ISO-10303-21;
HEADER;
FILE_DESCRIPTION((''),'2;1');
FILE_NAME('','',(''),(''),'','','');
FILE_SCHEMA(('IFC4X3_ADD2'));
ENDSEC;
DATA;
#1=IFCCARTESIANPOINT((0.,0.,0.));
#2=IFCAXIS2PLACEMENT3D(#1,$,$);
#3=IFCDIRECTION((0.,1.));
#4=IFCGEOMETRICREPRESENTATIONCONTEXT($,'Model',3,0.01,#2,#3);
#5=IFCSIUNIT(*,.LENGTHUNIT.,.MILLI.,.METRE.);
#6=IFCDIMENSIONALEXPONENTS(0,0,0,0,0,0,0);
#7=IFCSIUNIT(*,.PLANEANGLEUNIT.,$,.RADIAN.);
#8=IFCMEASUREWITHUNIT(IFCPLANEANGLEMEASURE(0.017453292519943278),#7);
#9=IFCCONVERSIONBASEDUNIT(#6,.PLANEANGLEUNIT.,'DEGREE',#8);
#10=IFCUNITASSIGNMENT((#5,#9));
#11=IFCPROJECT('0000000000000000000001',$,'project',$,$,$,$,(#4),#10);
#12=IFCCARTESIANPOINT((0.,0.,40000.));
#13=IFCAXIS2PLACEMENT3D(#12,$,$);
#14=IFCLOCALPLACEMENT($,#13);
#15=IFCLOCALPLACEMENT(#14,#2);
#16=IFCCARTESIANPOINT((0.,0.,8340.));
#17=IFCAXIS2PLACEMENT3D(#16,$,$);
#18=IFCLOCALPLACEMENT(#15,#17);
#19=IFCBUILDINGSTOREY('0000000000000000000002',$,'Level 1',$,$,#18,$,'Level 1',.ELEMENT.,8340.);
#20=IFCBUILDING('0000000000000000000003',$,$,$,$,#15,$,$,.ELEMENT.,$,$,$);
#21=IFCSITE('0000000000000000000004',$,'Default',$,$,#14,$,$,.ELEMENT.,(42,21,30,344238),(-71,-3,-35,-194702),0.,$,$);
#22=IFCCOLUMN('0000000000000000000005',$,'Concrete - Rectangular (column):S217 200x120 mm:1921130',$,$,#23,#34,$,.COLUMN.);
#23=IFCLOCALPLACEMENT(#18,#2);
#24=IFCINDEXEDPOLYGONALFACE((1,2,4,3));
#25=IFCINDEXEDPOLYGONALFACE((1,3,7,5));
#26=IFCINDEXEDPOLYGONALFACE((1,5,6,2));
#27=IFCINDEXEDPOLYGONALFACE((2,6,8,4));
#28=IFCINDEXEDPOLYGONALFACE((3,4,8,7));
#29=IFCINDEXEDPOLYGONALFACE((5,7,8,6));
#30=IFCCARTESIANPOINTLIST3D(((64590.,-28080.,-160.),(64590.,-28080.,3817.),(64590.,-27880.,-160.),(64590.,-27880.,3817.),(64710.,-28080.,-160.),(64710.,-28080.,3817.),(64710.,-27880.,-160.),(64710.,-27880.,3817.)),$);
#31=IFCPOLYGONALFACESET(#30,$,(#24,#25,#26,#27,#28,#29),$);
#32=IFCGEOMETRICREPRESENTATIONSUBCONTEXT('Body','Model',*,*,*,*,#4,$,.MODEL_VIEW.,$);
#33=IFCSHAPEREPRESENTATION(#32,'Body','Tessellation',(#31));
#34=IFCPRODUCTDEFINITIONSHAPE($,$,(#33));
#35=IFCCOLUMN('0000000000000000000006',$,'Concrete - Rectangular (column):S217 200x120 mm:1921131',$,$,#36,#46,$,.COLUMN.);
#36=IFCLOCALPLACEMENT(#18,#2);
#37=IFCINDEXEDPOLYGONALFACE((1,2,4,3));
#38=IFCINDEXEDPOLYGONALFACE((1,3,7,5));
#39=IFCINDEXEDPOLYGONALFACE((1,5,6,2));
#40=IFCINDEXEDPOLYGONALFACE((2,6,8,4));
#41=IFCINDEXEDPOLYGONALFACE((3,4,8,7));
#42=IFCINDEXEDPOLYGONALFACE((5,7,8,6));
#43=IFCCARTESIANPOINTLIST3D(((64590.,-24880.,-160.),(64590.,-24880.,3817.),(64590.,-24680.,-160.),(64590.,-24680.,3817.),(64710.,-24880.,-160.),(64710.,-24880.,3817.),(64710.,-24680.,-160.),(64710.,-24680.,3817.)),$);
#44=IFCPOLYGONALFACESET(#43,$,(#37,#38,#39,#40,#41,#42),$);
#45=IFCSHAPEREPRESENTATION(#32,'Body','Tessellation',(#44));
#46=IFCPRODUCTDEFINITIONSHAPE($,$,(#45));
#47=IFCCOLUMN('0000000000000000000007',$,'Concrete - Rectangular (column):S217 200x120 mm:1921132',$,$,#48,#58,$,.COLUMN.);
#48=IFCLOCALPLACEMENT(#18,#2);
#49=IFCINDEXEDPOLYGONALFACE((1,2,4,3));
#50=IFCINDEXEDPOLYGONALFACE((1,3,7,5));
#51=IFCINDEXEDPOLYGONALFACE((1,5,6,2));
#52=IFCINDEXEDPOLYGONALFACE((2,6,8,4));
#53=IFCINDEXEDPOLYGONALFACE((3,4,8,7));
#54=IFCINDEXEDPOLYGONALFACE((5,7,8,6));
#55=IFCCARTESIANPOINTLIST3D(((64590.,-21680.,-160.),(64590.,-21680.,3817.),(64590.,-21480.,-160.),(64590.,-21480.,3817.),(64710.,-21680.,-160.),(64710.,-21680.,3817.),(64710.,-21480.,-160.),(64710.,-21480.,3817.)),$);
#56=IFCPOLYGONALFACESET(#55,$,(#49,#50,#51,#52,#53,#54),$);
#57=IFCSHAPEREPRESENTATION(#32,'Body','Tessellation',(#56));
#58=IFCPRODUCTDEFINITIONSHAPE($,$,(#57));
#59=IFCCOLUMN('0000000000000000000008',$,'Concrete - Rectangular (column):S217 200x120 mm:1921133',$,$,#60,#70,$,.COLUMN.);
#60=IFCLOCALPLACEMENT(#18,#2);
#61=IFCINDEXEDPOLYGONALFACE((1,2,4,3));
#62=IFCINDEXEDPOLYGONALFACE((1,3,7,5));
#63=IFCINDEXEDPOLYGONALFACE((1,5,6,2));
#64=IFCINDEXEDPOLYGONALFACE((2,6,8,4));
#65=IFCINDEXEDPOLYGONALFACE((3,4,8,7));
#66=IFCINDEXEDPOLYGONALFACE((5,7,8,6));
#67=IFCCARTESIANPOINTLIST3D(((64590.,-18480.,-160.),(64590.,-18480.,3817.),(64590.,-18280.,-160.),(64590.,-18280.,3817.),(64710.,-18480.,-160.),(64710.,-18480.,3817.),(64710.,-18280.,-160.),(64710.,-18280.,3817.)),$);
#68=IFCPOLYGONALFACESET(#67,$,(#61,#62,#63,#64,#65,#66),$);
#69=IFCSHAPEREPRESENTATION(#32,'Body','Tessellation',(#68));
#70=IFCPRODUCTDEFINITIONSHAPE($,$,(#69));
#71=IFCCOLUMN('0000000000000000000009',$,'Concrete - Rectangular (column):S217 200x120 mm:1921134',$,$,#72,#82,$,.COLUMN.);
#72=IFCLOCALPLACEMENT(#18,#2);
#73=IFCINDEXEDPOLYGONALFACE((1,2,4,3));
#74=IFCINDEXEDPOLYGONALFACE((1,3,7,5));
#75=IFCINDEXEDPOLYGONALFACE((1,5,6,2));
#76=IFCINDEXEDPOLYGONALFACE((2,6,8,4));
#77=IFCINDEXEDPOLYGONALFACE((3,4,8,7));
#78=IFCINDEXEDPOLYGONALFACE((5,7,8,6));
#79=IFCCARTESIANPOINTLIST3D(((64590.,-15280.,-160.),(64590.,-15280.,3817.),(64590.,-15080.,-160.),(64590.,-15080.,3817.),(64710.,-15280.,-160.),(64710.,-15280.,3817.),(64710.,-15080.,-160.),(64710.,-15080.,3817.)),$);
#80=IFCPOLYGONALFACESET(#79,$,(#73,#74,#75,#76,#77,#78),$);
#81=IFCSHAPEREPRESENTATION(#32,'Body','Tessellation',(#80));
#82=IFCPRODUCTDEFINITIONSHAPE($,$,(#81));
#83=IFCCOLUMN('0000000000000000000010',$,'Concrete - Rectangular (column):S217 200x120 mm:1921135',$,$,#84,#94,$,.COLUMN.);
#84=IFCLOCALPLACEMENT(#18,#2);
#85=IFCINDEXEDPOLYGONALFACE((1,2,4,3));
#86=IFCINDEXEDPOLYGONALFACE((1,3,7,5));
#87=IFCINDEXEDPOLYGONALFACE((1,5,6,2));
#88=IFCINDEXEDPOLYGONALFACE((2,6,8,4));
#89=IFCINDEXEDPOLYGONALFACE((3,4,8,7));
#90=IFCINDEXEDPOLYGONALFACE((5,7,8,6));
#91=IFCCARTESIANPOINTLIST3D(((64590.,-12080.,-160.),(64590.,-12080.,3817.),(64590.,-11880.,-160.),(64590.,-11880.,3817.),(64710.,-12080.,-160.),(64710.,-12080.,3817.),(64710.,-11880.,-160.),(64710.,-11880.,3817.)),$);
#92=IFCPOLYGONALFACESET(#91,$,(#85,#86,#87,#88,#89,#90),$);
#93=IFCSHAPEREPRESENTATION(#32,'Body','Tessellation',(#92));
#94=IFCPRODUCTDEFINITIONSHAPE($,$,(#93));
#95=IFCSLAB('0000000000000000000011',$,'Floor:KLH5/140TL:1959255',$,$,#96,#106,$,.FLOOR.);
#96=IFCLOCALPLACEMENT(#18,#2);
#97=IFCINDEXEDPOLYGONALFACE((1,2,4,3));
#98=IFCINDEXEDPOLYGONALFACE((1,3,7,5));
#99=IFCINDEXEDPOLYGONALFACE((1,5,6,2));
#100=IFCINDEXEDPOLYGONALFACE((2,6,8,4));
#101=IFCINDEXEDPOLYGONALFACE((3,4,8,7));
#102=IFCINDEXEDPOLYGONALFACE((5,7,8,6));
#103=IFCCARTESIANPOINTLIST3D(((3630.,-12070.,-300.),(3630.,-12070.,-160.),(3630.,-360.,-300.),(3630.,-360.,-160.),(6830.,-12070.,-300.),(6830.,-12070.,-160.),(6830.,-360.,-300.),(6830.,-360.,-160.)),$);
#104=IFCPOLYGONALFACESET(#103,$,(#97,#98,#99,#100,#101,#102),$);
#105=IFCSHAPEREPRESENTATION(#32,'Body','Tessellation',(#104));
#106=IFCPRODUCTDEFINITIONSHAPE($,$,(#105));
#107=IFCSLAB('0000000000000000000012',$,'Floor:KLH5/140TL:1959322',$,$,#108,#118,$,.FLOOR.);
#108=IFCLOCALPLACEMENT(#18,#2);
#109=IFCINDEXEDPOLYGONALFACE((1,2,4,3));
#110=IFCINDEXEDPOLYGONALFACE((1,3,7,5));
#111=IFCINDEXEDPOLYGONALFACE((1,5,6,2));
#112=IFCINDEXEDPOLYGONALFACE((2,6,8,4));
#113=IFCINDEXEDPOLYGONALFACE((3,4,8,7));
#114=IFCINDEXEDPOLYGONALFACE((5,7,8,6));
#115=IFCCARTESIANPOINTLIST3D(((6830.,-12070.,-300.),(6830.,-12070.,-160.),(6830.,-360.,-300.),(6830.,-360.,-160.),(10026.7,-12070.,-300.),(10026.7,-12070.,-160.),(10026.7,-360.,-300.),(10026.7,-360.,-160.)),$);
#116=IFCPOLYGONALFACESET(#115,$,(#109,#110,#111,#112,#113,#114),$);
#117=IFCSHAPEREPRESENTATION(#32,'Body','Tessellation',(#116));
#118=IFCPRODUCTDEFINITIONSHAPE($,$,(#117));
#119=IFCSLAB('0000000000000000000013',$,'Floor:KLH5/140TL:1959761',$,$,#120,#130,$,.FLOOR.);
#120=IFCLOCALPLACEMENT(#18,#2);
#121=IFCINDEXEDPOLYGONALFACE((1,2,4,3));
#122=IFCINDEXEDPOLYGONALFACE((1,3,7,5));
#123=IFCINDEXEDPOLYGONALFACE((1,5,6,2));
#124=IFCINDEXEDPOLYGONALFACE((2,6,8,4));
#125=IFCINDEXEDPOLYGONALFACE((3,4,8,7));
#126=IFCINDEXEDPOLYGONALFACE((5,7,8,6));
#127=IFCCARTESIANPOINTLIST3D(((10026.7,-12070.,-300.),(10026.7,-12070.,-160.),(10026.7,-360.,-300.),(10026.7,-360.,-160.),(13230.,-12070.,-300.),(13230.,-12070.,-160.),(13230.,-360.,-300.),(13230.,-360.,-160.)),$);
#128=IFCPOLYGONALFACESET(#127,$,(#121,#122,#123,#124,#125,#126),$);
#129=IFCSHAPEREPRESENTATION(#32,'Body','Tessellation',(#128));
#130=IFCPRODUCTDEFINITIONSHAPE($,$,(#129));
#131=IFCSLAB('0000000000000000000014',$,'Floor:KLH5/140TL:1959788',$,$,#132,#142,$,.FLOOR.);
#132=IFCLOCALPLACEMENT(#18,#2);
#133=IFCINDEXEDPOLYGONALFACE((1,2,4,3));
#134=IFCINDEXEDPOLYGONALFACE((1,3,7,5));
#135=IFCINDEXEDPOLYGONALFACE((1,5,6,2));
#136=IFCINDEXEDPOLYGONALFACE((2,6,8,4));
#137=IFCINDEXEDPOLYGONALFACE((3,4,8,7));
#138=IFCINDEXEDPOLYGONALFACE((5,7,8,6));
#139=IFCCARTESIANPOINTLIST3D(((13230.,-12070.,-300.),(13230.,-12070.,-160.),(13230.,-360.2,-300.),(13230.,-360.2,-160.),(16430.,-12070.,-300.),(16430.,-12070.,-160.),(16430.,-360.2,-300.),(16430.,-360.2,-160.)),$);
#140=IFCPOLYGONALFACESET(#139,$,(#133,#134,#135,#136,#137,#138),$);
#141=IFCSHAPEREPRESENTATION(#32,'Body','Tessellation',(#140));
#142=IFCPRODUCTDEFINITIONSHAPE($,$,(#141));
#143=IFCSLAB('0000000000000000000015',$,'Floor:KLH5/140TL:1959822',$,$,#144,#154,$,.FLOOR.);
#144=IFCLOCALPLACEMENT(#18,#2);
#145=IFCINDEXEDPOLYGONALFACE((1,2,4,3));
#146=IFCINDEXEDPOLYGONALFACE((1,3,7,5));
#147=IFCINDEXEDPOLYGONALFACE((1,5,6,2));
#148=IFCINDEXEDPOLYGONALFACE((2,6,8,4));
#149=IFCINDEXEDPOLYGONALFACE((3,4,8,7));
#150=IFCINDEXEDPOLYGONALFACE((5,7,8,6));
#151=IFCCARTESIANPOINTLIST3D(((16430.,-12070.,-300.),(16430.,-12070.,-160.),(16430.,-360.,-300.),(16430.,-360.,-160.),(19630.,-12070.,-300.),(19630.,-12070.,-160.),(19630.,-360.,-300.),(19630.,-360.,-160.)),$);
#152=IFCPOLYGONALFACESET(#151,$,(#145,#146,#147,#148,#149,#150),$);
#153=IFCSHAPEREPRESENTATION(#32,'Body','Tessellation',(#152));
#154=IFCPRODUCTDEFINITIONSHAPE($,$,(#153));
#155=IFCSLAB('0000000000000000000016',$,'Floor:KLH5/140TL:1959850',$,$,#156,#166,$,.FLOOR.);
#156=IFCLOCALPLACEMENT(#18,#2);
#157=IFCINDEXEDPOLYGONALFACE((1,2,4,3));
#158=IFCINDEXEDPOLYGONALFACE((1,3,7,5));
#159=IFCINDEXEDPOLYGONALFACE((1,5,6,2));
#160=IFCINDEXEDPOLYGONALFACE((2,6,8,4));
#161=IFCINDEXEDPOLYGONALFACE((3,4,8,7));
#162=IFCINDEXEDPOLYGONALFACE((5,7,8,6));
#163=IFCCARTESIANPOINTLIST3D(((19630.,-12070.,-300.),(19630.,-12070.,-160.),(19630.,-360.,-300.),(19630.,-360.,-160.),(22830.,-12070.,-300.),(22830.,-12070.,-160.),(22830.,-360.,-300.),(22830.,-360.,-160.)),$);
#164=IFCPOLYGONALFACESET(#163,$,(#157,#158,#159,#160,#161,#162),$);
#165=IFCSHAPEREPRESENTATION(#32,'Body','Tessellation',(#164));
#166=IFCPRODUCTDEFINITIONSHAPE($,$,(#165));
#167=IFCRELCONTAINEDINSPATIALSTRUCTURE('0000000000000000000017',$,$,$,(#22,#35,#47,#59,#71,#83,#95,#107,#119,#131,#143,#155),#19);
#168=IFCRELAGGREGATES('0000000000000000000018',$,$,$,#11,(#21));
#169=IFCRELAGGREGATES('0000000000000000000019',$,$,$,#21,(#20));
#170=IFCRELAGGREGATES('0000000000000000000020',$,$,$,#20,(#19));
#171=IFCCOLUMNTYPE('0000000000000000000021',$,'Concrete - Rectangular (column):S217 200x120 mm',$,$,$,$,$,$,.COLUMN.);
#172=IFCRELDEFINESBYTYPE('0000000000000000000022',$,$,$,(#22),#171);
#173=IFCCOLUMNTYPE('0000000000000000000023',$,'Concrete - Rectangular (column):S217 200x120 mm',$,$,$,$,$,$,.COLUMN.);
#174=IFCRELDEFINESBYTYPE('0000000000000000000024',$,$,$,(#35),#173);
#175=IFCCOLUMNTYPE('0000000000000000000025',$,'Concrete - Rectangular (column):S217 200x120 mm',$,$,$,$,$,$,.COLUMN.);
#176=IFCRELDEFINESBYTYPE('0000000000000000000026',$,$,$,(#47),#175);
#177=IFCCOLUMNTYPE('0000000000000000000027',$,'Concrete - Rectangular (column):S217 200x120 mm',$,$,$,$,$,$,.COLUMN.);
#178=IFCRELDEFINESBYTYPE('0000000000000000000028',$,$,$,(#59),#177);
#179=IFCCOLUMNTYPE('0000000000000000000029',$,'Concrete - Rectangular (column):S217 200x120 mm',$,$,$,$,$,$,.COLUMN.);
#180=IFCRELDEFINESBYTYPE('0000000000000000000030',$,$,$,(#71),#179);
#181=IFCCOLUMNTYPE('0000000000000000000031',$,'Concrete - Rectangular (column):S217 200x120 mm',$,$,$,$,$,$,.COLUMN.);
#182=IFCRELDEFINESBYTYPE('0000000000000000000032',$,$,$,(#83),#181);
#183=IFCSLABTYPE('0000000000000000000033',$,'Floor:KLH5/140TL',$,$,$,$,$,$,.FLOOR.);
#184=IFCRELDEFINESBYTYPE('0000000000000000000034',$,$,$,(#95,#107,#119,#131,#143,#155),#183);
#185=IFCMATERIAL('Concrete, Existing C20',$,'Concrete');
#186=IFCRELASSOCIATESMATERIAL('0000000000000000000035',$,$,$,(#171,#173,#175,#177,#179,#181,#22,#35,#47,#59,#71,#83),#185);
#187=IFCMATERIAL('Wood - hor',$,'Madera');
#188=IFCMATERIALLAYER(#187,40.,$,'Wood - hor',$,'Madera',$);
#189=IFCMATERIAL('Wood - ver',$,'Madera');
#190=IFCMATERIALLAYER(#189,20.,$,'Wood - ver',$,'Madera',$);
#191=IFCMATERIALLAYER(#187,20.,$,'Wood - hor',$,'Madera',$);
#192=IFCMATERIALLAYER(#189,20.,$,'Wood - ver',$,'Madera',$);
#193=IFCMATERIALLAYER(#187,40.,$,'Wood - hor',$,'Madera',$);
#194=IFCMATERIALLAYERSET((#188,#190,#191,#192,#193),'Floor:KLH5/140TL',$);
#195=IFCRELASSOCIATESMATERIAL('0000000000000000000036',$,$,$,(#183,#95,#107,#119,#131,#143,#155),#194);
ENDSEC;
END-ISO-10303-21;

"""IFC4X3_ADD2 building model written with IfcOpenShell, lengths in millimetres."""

from ifc_helpers import new_model, entity, si_unit, converted_unit, direction, frame, frame_2d, origin, origin_2d_with_axis, place, context, subcontext, project, spatial, rectangle, extrude, source, transform, mapped, material, layer, layer_set, layer_usage, material_profile, profile_set, profile_usage, type_object, type_shapes, element, save


model = new_model("IFC4X3_ADD2")

# Units and contexts
model_context = context("Model", 3, precision=0.01, world=origin(), true_north=direction((0.0, 1.0)))
body_context = subcontext(model_context, "Body", "Model", "MODEL_VIEW")
ifc_project = project(units=[si_unit("LENGTHUNIT", "METRE", prefix="MILLI"), converted_unit("PLANEANGLEUNIT", "DEGREE", entity("IfcPlaneAngleMeasure", 0.017453292519943278), si_unit("PLANEANGLEUNIT", "RADIAN"), dimensions=[0, 0, 0, 0, 0, 0, 0])], contexts=[model_context])

# Site, building, storey
site_placement = place(None, frame((0.0, 0.0, 40000.0)))
site = spatial("IfcSite", under=ifc_project, at=site_placement, Name="Default", CompositionType="ELEMENT", RefLatitude=(42, 21, 30, 344238), RefLongitude=(-71, -3, -35, -194702), RefElevation=0.0)
building_placement = place(site_placement, origin())
building = spatial("IfcBuilding", under=site, at=building_placement, CompositionType="ELEMENT")
storey_placement = place(building_placement, frame((0.0, 0.0, 8340.0)))
storey = spatial("IfcBuildingStorey", under=building, at=storey_placement, Name="Level 1", LongName="Level 1", CompositionType="ELEMENT", Elevation=8340.0)

# Columns
ifc_material_1 = material(Name="Concrete, Existing C20", Category="Concrete")
ifc_material_profile_1 = material_profile(ifc_material_1, rectangle(XDim=200.0, YDim=120.0, at=frame_2d((0.0, 0.0), x_axis=(1.0, 0.0))), Name="S217 200x120 mm")
ifc_profile_set_1 = profile_set([ifc_material_profile_1], Name="S217 200x120 mm")
ifc_profile_usage_1 = profile_usage(ifc_profile_set_1)
column_type_1 = type_object("IfcColumnType", Name="Concrete - Rectangular (column):S217 200x120 mm", PredefinedType="COLUMN", material=ifc_profile_set_1)
shared_shape_1 = source(origin(), body_context, "Body", "SweptSolid", [
    extrude(rectangle(XDim=200.0, YDim=120.0, at=frame_2d((0.0, 0.0), x_axis=(1.0, 0.0))), frame((64650.0, -27980.0, 8180.0), z_axis=(0.0, 0.0, 1.0), x_axis=(0.0, 1.0, 0.0)), (0.0, 0.0, 1.0), 3977.0),
])
type_shapes(column_type_1, [shared_shape_1])
column_1_placement = place(storey_placement, frame((0.0, 0.0, -8340.0)))
element("IfcColumn", 1, at=column_1_placement, inside=storey, type_object=column_type_1, material=ifc_profile_usage_1, Name="Concrete - Rectangular (column):S217 200x120 mm:1921130", PredefinedType="COLUMN", context=body_context, shape_type="MappedRepresentation", body=[
    mapped(shared_shape_1, transform((0.0, 0.0, 0.0), scale=1.0)),
])
column_type_2 = type_object("IfcColumnType", Name="Concrete - Rectangular (column):S217 200x120 mm", PredefinedType="COLUMN", material=ifc_profile_set_1)
shared_shape_2 = source(origin(), body_context, "Body", "SweptSolid", [
    extrude(rectangle(XDim=200.0, YDim=120.0, at=frame_2d((0.0, 0.0), x_axis=(1.0, 0.0))), frame((64650.0, -24780.0, 8180.0), z_axis=(0.0, 0.0, 1.0), x_axis=(0.0, 1.0, 0.0)), (0.0, 0.0, 1.0), 3977.0),
])
type_shapes(column_type_2, [shared_shape_2])
column_2_placement = place(storey_placement, frame((0.0, 0.0, -8340.0)))
element("IfcColumn", 2, at=column_2_placement, inside=storey, type_object=column_type_2, material=ifc_profile_usage_1, Name="Concrete - Rectangular (column):S217 200x120 mm:1921131", PredefinedType="COLUMN", context=body_context, shape_type="MappedRepresentation", body=[
    mapped(shared_shape_2, transform((0.0, 0.0, 0.0), scale=1.0)),
])
column_type_3 = type_object("IfcColumnType", Name="Concrete - Rectangular (column):S217 200x120 mm", PredefinedType="COLUMN", material=ifc_profile_set_1)
shared_shape_3 = source(origin(), body_context, "Body", "SweptSolid", [
    extrude(rectangle(XDim=200.0, YDim=120.0, at=frame_2d((0.0, 0.0), x_axis=(1.0, 0.0))), frame((64650.0, -21580.0, 8180.0), z_axis=(0.0, 0.0, 1.0), x_axis=(0.0, 1.0, 0.0)), (0.0, 0.0, 1.0), 3977.0),
])
type_shapes(column_type_3, [shared_shape_3])
column_3_placement = place(storey_placement, frame((0.0, 0.0, -8340.0)))
element("IfcColumn", 3, at=column_3_placement, inside=storey, type_object=column_type_3, material=ifc_profile_usage_1, Name="Concrete - Rectangular (column):S217 200x120 mm:1921132", PredefinedType="COLUMN", context=body_context, shape_type="MappedRepresentation", body=[
    mapped(shared_shape_3, transform((0.0, 0.0, 0.0), scale=1.0)),
])
column_type_4 = type_object("IfcColumnType", Name="Concrete - Rectangular (column):S217 200x120 mm", PredefinedType="COLUMN", material=ifc_profile_set_1)
shared_shape_4 = source(origin(), body_context, "Body", "SweptSolid", [
    extrude(rectangle(XDim=200.0, YDim=120.0, at=frame_2d((0.0, 0.0), x_axis=(1.0, 0.0))), frame((64650.0, -18380.0, 8180.0), z_axis=(0.0, 0.0, 1.0), x_axis=(0.0, 1.0, 0.0)), (0.0, 0.0, 1.0), 3977.0),
])
type_shapes(column_type_4, [shared_shape_4])
column_4_placement = place(storey_placement, frame((0.0, 0.0, -8340.0)))
element("IfcColumn", 4, at=column_4_placement, inside=storey, type_object=column_type_4, material=ifc_profile_usage_1, Name="Concrete - Rectangular (column):S217 200x120 mm:1921133", PredefinedType="COLUMN", context=body_context, shape_type="MappedRepresentation", body=[
    mapped(shared_shape_4, transform((0.0, 0.0, 0.0), scale=1.0)),
])
column_type_5 = type_object("IfcColumnType", Name="Concrete - Rectangular (column):S217 200x120 mm", PredefinedType="COLUMN", material=ifc_profile_set_1)
shared_shape_5 = source(origin(), body_context, "Body", "SweptSolid", [
    extrude(rectangle(XDim=200.0, YDim=120.0, at=frame_2d((0.0, 0.0), x_axis=(1.0, 0.0))), frame((64650.0, -15180.0, 8180.0), z_axis=(0.0, 0.0, 1.0), x_axis=(0.0, 1.0, 0.0)), (0.0, 0.0, 1.0), 3977.0),
])
type_shapes(column_type_5, [shared_shape_5])
column_5_placement = place(storey_placement, frame((0.0, 0.0, -8340.0)))
element("IfcColumn", 5, at=column_5_placement, inside=storey, type_object=column_type_5, material=ifc_profile_usage_1, Name="Concrete - Rectangular (column):S217 200x120 mm:1921134", PredefinedType="COLUMN", context=body_context, shape_type="MappedRepresentation", body=[
    mapped(shared_shape_5, transform((0.0, 0.0, 0.0), scale=1.0)),
])
column_type_6 = type_object("IfcColumnType", Name="Concrete - Rectangular (column):S217 200x120 mm", PredefinedType="COLUMN", material=ifc_profile_set_1)
shared_shape_6 = source(origin(), body_context, "Body", "SweptSolid", [
    extrude(rectangle(XDim=200.0, YDim=120.0, at=frame_2d((0.0, 0.0), x_axis=(1.0, 0.0))), frame((64650.0, -11980.0, 8180.0), z_axis=(0.0, 0.0, 1.0), x_axis=(0.0, 1.0, 0.0)), (0.0, 0.0, 1.0), 3977.0),
])
type_shapes(column_type_6, [shared_shape_6])
column_6_placement = place(storey_placement, frame((0.0, 0.0, -8340.0)))
element("IfcColumn", 6, at=column_6_placement, inside=storey, type_object=column_type_6, material=ifc_profile_usage_1, Name="Concrete - Rectangular (column):S217 200x120 mm:1921135", PredefinedType="COLUMN", context=body_context, shape_type="MappedRepresentation", body=[
    mapped(shared_shape_6, transform((0.0, 0.0, 0.0), scale=1.0)),
])

# Slabs
ifc_material_2 = material(Name="Wood - hor", Category="Madera")
ifc_layer_1 = layer(ifc_material_2, 40.0, Name="Wood - hor", Category="Madera")
ifc_material_3 = material(Name="Wood - ver", Category="Madera")
ifc_layer_2 = layer(ifc_material_3, 20.0, Name="Wood - ver", Category="Madera")
ifc_layer_3 = layer(ifc_material_2, 20.0, Name="Wood - hor", Category="Madera")
ifc_layer_4 = layer(ifc_material_3, 20.0, Name="Wood - ver", Category="Madera")
ifc_layer_5 = layer(ifc_material_2, 40.0, Name="Wood - hor", Category="Madera")
ifc_layer_set = layer_set([ifc_layer_1, ifc_layer_2, ifc_layer_3, ifc_layer_4, ifc_layer_5], Name="Floor:KLH5/140TL")
ifc_layer_usage_1 = layer_usage(ifc_layer_set, "AXIS3", "POSITIVE", 0.0)
slab_type = type_object("IfcSlabType", Name="Floor:KLH5/140TL", PredefinedType="FLOOR", material=ifc_layer_set)
slab_1_placement = place(storey_placement, origin())
element("IfcSlab", 7, at=slab_1_placement, inside=storey, type_object=slab_type, material=ifc_layer_usage_1, Name="Floor:KLH5/140TL:1959255", PredefinedType="FLOOR", context=body_context, shape_type="SweptSolid", body=[
    extrude(rectangle(XDim=11710.0, YDim=3200.0, at=frame_2d((0.0, 0.0), x_axis=(1.0, 0.0))), frame((5230.0, -6215.0, -160.0), z_axis=(0.0, 0.0, -1.0), x_axis=(0.0, 1.0, 0.0)), (0.0, 0.0, 1.0), 140.0),
])
ifc_layer_usage_2 = layer_usage(ifc_layer_set, "AXIS3", "POSITIVE", 0.0)
slab_2_placement = place(storey_placement, origin())
element("IfcSlab", 8, at=slab_2_placement, inside=storey, type_object=slab_type, material=ifc_layer_usage_2, Name="Floor:KLH5/140TL:1959322", PredefinedType="FLOOR", context=body_context, shape_type="SweptSolid", body=[
    extrude(rectangle(XDim=11710.0, YDim=3196.7, at=frame_2d((0.0, 0.0), x_axis=(1.0, 0.0))), frame((8428.4, -6215.0, -160.0), z_axis=(0.0, 0.0, -1.0), x_axis=(0.0, 1.0, 0.0)), (0.0, 0.0, 1.0), 140.0),
])
ifc_layer_usage_3 = layer_usage(ifc_layer_set, "AXIS3", "POSITIVE", 0.0)
slab_3_placement = place(storey_placement, origin())
element("IfcSlab", 9, at=slab_3_placement, inside=storey, type_object=slab_type, material=ifc_layer_usage_3, Name="Floor:KLH5/140TL:1959761", PredefinedType="FLOOR", context=body_context, shape_type="SweptSolid", body=[
    extrude(rectangle(XDim=11710.0, YDim=3203.3, at=origin_2d_with_axis()), frame((11628.4, -6215.0, -160.0), z_axis=(0.0, 0.0, -1.0), x_axis=(0.0, 1.0, 0.0)), (0.0, 0.0, 1.0), 140.0),
])
ifc_layer_usage_4 = layer_usage(ifc_layer_set, "AXIS3", "POSITIVE", 0.0)
slab_4_placement = place(storey_placement, origin())
element("IfcSlab", 10, at=slab_4_placement, inside=storey, type_object=slab_type, material=ifc_layer_usage_4, Name="Floor:KLH5/140TL:1959788", PredefinedType="FLOOR", context=body_context, shape_type="SweptSolid", body=[
    extrude(rectangle(XDim=11709.8, YDim=3200.0, at=origin_2d_with_axis()), frame((14830.0, -6215.1, -160.0), z_axis=(0.0, 0.0, -1.0), x_axis=(0.0, 1.0, 0.0)), (0.0, 0.0, 1.0), 140.0),
])
ifc_layer_usage_5 = layer_usage(ifc_layer_set, "AXIS3", "POSITIVE", 0.0)
slab_5_placement = place(storey_placement, origin())
element("IfcSlab", 11, at=slab_5_placement, inside=storey, type_object=slab_type, material=ifc_layer_usage_5, Name="Floor:KLH5/140TL:1959822", PredefinedType="FLOOR", context=body_context, shape_type="SweptSolid", body=[
    extrude(rectangle(XDim=11710.0, YDim=3200.0, at=origin_2d_with_axis()), frame((18030.0, -6215.0, -160.0), z_axis=(0.0, 0.0, -1.0), x_axis=(0.0, 1.0, 0.0)), (0.0, 0.0, 1.0), 140.0),
])
ifc_layer_usage_6 = layer_usage(ifc_layer_set, "AXIS3", "POSITIVE", 0.0)
slab_6_placement = place(storey_placement, origin())
element("IfcSlab", 12, at=slab_6_placement, inside=storey, type_object=slab_type, material=ifc_layer_usage_6, Name="Floor:KLH5/140TL:1959850", PredefinedType="FLOOR", context=body_context, shape_type="SweptSolid", body=[
    extrude(rectangle(XDim=11710.0, YDim=3200.0, at=origin_2d_with_axis()), frame((21230.0, -6215.0, -160.0), z_axis=(0.0, 0.0, -1.0), x_axis=(0.0, 1.0, 0.0)), (0.0, 0.0, 1.0), 140.0),
])

save(model, "model.ifc")
